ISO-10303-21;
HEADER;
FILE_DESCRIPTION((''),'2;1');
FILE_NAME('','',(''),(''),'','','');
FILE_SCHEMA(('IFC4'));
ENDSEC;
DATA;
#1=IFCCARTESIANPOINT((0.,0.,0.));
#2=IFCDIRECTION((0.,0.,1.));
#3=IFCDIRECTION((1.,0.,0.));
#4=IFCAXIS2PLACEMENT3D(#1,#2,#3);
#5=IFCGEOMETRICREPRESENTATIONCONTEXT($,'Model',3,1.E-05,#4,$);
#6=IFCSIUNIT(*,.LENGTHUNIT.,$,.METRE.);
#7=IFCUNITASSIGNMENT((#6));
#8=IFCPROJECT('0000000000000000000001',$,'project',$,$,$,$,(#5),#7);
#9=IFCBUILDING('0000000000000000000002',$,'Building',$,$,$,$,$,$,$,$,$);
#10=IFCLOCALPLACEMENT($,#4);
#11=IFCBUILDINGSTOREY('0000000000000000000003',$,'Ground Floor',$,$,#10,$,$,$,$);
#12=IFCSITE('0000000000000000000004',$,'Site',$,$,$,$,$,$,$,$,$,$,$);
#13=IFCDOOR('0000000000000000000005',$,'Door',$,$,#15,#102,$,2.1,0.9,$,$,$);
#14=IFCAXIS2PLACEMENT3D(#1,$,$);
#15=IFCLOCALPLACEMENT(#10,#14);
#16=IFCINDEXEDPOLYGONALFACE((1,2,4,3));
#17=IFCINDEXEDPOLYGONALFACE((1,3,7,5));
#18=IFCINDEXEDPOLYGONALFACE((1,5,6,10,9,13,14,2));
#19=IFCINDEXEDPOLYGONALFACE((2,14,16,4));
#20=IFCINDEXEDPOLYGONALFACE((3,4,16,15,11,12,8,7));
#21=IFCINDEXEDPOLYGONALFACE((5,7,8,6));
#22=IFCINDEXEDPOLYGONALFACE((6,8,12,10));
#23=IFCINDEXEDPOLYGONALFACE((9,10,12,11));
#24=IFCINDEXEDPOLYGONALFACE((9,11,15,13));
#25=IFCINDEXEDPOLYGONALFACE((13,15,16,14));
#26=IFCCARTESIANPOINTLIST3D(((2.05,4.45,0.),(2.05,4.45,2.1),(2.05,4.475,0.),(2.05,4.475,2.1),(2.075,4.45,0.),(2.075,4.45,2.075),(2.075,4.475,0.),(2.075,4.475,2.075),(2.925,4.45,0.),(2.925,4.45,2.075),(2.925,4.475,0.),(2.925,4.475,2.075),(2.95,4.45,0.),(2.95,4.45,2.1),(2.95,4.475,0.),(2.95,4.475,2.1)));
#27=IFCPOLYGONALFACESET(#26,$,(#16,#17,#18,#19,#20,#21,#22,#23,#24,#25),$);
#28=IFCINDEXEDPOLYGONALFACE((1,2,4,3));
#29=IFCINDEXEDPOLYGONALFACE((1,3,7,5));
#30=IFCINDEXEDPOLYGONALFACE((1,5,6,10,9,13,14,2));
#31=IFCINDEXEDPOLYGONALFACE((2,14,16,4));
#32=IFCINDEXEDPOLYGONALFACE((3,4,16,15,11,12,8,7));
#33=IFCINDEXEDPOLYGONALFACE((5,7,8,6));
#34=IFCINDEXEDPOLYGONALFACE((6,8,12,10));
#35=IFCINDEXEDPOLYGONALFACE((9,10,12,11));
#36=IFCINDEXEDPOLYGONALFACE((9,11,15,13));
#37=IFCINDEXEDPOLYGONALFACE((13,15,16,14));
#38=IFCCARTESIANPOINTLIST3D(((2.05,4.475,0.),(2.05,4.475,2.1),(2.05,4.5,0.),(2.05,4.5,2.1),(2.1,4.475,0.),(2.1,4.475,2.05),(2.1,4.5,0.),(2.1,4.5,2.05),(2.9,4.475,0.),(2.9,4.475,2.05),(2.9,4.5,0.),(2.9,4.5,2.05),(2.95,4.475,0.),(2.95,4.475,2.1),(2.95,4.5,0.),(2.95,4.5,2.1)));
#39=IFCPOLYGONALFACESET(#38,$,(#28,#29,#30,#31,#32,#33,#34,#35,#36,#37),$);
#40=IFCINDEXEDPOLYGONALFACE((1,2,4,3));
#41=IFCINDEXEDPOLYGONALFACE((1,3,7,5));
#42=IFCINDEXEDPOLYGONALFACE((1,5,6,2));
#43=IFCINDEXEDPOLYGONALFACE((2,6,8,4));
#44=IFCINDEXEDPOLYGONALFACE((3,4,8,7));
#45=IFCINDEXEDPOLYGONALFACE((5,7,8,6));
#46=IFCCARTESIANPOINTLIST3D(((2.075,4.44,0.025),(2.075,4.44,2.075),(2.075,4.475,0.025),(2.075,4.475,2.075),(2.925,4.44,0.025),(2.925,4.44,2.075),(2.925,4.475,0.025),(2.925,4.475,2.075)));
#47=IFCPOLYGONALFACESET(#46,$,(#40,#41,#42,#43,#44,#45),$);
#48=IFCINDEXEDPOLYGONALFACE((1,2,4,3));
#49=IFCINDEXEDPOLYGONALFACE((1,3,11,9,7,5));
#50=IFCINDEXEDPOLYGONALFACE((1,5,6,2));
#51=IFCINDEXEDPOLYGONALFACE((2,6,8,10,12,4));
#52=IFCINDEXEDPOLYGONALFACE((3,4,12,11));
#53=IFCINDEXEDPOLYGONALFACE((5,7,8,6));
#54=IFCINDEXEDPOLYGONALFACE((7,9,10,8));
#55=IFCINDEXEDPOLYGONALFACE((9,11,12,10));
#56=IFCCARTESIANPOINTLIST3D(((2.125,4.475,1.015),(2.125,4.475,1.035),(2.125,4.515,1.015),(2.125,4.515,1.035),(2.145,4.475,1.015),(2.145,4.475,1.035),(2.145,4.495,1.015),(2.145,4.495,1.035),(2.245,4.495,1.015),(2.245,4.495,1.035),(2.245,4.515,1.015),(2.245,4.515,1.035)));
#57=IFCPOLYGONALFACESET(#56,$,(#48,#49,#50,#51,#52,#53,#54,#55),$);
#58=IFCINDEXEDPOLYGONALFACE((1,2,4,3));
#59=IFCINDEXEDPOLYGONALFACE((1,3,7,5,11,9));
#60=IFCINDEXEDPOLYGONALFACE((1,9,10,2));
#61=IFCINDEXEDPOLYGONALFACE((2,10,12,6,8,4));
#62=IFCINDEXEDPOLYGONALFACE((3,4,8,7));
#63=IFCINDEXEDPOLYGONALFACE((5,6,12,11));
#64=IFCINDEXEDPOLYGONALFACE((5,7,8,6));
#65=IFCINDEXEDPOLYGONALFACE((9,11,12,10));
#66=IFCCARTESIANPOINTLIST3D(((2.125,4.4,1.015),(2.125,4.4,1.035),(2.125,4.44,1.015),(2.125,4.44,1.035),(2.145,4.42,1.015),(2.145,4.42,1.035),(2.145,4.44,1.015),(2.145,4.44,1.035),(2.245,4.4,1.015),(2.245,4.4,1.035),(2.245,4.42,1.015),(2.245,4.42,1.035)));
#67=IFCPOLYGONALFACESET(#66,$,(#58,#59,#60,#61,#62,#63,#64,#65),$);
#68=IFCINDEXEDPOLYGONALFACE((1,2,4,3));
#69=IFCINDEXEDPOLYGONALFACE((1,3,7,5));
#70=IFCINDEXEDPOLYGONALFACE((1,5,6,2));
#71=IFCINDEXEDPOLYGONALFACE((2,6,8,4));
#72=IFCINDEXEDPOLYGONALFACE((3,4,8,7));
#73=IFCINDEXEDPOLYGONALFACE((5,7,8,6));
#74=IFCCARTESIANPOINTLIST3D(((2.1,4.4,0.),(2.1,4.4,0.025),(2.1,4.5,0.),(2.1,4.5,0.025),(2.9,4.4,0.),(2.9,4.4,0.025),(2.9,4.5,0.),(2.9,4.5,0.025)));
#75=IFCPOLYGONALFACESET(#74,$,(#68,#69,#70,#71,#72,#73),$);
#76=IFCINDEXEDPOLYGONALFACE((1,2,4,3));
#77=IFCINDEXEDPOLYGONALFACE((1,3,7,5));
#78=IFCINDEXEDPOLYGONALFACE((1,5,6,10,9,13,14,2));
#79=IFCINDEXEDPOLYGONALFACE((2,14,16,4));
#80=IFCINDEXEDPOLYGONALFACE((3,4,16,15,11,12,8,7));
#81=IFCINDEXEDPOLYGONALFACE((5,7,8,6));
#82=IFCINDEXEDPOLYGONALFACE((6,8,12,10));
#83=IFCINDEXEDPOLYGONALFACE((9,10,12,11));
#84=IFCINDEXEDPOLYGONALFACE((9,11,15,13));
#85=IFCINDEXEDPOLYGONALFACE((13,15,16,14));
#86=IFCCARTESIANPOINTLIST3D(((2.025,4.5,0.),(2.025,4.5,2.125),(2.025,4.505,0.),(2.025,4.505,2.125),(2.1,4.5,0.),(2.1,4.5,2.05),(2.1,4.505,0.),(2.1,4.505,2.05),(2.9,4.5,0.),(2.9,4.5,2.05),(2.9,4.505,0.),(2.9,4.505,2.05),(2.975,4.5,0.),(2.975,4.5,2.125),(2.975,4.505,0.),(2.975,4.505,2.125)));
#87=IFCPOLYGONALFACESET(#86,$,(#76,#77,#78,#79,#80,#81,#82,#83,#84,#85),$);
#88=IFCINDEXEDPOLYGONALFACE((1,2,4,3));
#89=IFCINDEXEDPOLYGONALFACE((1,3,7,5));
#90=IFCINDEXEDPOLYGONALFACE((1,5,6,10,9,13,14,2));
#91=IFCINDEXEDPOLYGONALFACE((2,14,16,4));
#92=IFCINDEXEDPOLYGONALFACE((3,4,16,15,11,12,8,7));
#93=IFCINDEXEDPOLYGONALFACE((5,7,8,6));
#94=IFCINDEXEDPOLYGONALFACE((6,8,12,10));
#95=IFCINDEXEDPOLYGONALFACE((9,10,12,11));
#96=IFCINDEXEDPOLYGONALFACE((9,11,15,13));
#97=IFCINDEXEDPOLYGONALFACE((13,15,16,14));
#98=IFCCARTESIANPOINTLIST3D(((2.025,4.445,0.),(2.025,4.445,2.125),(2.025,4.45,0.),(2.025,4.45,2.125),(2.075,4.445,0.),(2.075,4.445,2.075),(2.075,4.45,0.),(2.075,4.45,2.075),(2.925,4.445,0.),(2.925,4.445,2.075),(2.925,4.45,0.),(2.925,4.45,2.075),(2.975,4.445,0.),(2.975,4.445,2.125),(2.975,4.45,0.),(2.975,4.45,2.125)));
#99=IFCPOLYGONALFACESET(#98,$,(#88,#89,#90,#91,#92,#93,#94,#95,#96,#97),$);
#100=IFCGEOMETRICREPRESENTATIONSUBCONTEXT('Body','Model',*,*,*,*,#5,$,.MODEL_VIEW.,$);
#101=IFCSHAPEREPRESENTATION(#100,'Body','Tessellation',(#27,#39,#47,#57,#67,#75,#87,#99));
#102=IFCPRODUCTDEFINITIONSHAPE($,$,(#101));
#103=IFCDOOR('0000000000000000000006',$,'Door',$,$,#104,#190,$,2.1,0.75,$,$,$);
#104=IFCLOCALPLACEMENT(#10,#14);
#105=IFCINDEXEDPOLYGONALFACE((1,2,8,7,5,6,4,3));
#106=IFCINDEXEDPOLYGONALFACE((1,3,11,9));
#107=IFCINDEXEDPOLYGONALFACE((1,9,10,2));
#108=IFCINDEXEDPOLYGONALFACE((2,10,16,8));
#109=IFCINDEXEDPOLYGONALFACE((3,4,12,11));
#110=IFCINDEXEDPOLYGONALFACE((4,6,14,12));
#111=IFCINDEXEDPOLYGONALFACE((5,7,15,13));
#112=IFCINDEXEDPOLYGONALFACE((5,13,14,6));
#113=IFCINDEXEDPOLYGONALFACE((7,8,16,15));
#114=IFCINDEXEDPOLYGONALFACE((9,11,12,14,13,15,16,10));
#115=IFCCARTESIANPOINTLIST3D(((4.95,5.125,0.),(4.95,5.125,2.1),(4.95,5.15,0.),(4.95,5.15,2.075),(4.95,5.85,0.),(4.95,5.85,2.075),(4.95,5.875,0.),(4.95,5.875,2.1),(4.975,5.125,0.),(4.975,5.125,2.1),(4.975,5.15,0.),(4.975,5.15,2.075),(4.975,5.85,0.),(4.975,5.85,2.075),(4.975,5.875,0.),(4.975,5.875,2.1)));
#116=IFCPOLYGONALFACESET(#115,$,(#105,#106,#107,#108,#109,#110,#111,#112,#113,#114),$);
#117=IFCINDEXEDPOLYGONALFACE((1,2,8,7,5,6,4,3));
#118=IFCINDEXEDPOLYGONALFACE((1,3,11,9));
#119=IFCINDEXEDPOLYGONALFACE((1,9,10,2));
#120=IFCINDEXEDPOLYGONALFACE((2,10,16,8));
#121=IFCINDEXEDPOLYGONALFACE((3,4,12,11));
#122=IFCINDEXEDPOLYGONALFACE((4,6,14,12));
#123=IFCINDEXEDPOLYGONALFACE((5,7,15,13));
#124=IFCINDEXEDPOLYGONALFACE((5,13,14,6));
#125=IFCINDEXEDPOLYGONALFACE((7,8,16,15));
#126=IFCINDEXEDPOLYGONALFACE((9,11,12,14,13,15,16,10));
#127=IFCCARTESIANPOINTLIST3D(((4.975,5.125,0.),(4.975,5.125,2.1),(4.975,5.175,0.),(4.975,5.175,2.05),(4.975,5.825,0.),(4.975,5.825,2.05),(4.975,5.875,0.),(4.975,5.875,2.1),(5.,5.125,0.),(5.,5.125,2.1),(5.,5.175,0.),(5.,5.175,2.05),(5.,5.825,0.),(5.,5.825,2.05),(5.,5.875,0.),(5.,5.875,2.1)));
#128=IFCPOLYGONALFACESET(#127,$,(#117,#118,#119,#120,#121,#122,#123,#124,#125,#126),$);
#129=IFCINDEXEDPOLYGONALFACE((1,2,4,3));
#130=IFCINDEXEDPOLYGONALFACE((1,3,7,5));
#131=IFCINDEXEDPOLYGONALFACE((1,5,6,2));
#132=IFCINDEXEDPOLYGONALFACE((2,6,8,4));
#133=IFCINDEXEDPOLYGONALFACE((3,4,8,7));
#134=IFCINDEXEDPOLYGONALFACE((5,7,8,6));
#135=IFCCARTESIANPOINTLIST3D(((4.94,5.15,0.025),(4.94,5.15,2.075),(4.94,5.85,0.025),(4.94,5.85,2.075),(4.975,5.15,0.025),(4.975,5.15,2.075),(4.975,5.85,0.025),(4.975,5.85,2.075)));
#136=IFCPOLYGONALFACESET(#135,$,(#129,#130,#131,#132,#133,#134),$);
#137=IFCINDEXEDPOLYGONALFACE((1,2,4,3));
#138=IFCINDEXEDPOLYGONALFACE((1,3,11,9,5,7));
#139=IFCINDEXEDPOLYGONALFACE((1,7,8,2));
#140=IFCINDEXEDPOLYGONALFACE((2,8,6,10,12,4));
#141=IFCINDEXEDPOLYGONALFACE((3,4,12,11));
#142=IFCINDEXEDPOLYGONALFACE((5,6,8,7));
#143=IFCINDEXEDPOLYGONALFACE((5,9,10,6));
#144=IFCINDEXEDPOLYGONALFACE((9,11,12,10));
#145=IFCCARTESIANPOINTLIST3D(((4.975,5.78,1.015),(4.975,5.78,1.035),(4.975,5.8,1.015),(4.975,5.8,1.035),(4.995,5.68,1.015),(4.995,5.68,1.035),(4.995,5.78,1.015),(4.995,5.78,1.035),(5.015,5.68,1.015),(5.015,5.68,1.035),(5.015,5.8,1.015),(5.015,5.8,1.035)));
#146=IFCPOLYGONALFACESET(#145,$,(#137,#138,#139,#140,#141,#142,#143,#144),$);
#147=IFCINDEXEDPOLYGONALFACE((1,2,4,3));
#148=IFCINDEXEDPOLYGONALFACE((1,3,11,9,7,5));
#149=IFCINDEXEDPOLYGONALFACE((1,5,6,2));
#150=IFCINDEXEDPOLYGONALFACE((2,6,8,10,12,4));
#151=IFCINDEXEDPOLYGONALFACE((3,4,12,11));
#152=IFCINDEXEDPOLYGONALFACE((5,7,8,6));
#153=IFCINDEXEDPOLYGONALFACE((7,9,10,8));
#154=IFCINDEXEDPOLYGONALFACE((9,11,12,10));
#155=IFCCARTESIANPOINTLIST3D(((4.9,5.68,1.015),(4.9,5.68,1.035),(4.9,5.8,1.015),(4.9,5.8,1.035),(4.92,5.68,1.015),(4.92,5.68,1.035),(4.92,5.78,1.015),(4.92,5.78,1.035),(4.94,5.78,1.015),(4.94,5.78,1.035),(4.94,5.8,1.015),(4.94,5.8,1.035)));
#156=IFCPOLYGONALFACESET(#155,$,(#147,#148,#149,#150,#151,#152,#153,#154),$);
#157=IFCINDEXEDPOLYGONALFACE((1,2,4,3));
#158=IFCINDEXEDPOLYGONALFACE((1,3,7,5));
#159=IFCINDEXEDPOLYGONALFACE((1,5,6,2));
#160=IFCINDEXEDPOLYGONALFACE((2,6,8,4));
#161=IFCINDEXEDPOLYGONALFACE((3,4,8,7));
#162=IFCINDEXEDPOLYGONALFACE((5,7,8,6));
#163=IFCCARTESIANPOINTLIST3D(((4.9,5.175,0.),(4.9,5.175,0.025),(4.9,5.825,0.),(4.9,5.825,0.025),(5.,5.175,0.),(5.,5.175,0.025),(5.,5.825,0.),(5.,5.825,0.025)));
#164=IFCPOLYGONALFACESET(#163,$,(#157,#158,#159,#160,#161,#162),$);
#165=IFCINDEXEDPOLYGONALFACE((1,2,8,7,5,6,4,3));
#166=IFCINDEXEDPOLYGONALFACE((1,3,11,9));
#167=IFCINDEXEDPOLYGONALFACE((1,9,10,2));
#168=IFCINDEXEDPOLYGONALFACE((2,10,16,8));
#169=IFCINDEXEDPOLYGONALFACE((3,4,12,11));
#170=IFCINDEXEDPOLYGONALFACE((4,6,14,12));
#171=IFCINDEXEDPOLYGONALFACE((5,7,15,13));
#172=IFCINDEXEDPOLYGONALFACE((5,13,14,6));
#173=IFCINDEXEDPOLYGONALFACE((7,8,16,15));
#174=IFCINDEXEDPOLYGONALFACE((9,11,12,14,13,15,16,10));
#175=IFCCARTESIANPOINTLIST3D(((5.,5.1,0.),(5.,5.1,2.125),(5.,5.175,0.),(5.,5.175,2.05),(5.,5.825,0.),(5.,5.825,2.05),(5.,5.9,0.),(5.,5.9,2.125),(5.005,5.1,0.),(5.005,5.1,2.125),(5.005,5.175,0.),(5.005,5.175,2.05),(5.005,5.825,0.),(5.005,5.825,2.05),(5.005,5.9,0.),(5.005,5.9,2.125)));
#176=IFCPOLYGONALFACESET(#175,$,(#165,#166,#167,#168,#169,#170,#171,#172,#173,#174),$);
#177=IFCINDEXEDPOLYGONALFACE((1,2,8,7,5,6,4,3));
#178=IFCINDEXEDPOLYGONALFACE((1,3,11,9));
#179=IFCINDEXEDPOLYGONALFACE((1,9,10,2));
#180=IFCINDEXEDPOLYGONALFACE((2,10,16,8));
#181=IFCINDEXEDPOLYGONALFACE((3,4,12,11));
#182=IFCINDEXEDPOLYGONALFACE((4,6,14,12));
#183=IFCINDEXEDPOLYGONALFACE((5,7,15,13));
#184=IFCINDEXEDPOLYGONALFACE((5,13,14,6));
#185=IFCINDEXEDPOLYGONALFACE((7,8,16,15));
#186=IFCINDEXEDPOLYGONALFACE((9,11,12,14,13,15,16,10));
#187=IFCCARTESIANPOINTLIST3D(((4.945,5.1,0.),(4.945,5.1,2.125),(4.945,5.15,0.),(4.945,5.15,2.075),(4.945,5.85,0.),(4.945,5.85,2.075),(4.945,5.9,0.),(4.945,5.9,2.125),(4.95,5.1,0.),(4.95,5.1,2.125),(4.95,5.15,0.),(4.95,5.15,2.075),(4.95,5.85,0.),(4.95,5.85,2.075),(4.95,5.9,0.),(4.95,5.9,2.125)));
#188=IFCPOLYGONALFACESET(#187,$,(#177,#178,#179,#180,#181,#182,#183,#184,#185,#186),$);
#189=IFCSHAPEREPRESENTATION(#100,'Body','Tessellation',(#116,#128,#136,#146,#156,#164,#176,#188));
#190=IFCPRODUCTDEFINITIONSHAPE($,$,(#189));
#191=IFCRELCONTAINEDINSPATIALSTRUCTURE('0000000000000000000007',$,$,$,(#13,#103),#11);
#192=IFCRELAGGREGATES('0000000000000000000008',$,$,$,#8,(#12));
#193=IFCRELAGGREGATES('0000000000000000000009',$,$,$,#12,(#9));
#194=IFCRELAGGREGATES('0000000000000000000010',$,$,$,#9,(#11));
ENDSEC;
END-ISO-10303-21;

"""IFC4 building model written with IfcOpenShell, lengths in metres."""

from ifc_helpers import new_model, si_unit, frame, origin_with_axes, place, context, subcontext, project, spatial, line, indexed_curve, outline, extrude, element, save


model = new_model("IFC4")

# Units and contexts
model_context = context("Model", 3, precision=1e-05, world=origin_with_axes())
body_context = subcontext(model_context, "Body", "Model", "MODEL_VIEW")
ifc_project = project(units=[si_unit("LENGTHUNIT", "METRE")], contexts=[model_context])

# Site, building, storey
site = spatial("IfcSite", under=ifc_project, Name="Site")
building = spatial("IfcBuilding", under=site, Name="Building")
storey_placement = place(None, origin_with_axes())
storey = spatial("IfcBuildingStorey", under=building, at=storey_placement, Name="Ground Floor")

# Doors
door_1_placement = place(storey_placement, frame((2.95, 4.5, 0.0), z_axis=(0.0, 0.0, 1.0), x_axis=(-1.0, 0.0, 0.0)))
element("IfcDoor", 1, at=door_1_placement, inside=storey, Name="Door", OverallHeight=2.1, OverallWidth=0.9, context=body_context, shape_type="SweptSolid", body=[
    extrude(outline(indexed_curve([(0.0, 0.0), (0.0, 2.1), (0.9, 2.1), (0.9, 0.0), (0.875, 0.0), (0.875, 2.075), (0.025, 2.075), (0.025, 0.0)], segments=[line(1, 2, 3, 4, 5, 6, 7, 8, 1)])), frame((0.0, 0.025, 0.0), z_axis=(0.0, -1.0, 0.0), x_axis=(1.0, 0.0, 0.0)), (0.0, 0.0, -1.0), 0.025),
    extrude(outline(indexed_curve([(0.0, 0.0), (0.0, 2.1), (0.9, 2.1), (0.9, 0.0), (0.85, 0.0), (0.85, 2.05), (0.05, 2.05), (0.05, 0.0)], segments=[line(1, 2, 3, 4, 5, 6, 7, 8, 1)])), frame((0.0, 0.0, 0.0), z_axis=(0.0, -1.0, 0.0), x_axis=(1.0, 0.0, 0.0)), (0.0, 0.0, -1.0), 0.025),
    extrude(outline(indexed_curve([(0.0, 0.0), (0.85, 0.0), (0.85, 0.035), (0.0, 0.035)], segments=[line(1, 2, 3, 4, 1)])), frame((0.025, 0.025, 0.025), z_axis=(0.0, 0.0, 1.0), x_axis=(1.0, 0.0, 0.0)), (0.0, 0.0, 1.0), 2.05),
    extrude(outline(indexed_curve([(0.0, 0.0), (0.0, -0.04), (-0.12, -0.04), (-0.12, -0.02), (-0.02, -0.02), (-0.02, 0.0)], segments=[line(1, 2, 3, 4, 5, 6, 1)])), frame((0.825, 0.025, 1.015), z_axis=(0.0, 0.0, 1.0), x_axis=(1.0, 0.0, 0.0)), (0.0, 0.0, 1.0), 0.02),
    extrude(outline(indexed_curve([(0.0, 0.0), (0.0, 0.04), (-0.12, 0.04), (-0.12, 0.02), (-0.02, 0.02), (-0.02, 0.0)], segments=[line(1, 2, 3, 4, 5, 6, 1)])), frame((0.825, 0.06, 1.015), z_axis=(0.0, 0.0, 1.0), x_axis=(1.0, 0.0, 0.0)), (0.0, 0.0, 1.0), 0.02),
    extrude(outline(indexed_curve([(0.0, 0.0), (0.8, 0.0), (0.8, 0.1), (0.0, 0.1)], segments=[line(1, 2, 3, 4, 1)])), frame((0.05, 0.0, 0.0), z_axis=(0.0, 0.0, 1.0), x_axis=(1.0, 0.0, 0.0)), (0.0, 0.0, 1.0), 0.025),
    extrude(outline(indexed_curve([(0.0, 0.0), (0.0, 2.125), (0.95, 2.125), (0.95, 0.0), (0.875, 0.0), (0.875, 2.05), (0.075, 2.05), (0.075, 0.0)], segments=[line(1, 2, 3, 4, 5, 6, 7, 8, 1)])), frame((-0.025, -0.005, 0.0), z_axis=(0.0, -1.0, 0.0), x_axis=(1.0, 0.0, 0.0)), (0.0, 0.0, -1.0), 0.005),
    extrude(outline(indexed_curve([(0.0, 0.0), (0.0, 2.125), (0.95, 2.125), (0.95, 0.0), (0.9, 0.0), (0.9, 2.075), (0.05, 2.075), (0.05, 0.0)], segments=[line(1, 2, 3, 4, 5, 6, 7, 8, 1)])), frame((-0.025, 0.05, 0.0), z_axis=(0.0, -1.0, 0.0), x_axis=(1.0, 0.0, 0.0)), (0.0, 0.0, -1.0), 0.005),
])
door_2_placement = place(storey_placement, frame((5.0, 5.125, 0.0), z_axis=(0.0, 0.0, 1.0), x_axis=(0.0, 1.0, 0.0)))
element("IfcDoor", 2, at=door_2_placement, inside=storey, Name="Door", OverallHeight=2.1, OverallWidth=0.75, context=body_context, shape_type="SweptSolid", body=[
    extrude(outline(indexed_curve([(0.0, 0.0), (0.0, 2.1), (0.75, 2.1), (0.75, 0.0), (0.725, 0.0), (0.725, 2.075), (0.025, 2.075), (0.025, 0.0)], segments=[line(1, 2, 3, 4, 5, 6, 7, 8, 1)])), frame((0.0, 0.025, 0.0), z_axis=(0.0, -1.0, 0.0), x_axis=(1.0, 0.0, 0.0)), (0.0, 0.0, -1.0), 0.025),
    extrude(outline(indexed_curve([(0.0, 0.0), (0.0, 2.1), (0.75, 2.1), (0.75, 0.0), (0.7, 0.0), (0.7, 2.05), (0.05, 2.05), (0.05, 0.0)], segments=[line(1, 2, 3, 4, 5, 6, 7, 8, 1)])), frame((0.0, 0.0, 0.0), z_axis=(0.0, -1.0, 0.0), x_axis=(1.0, 0.0, 0.0)), (0.0, 0.0, -1.0), 0.025),
    extrude(outline(indexed_curve([(0.0, 0.0), (0.7, 0.0), (0.7, 0.035), (0.0, 0.035)], segments=[line(1, 2, 3, 4, 1)])), frame((0.025, 0.025, 0.025), z_axis=(0.0, 0.0, 1.0), x_axis=(1.0, 0.0, 0.0)), (0.0, 0.0, 1.0), 2.05),
    extrude(outline(indexed_curve([(0.0, 0.0), (0.0, -0.04), (-0.12, -0.04), (-0.12, -0.02), (-0.02, -0.02), (-0.02, 0.0)], segments=[line(1, 2, 3, 4, 5, 6, 1)])), frame((0.675, 0.025, 1.015), z_axis=(0.0, 0.0, 1.0), x_axis=(1.0, 0.0, 0.0)), (0.0, 0.0, 1.0), 0.02),
    extrude(outline(indexed_curve([(0.0, 0.0), (0.0, 0.04), (-0.12, 0.04), (-0.12, 0.02), (-0.02, 0.02), (-0.02, 0.0)], segments=[line(1, 2, 3, 4, 5, 6, 1)])), frame((0.675, 0.06, 1.015), z_axis=(0.0, 0.0, 1.0), x_axis=(1.0, 0.0, 0.0)), (0.0, 0.0, 1.0), 0.02),
    extrude(outline(indexed_curve([(0.0, 0.0), (0.65, 0.0), (0.65, 0.1), (0.0, 0.1)], segments=[line(1, 2, 3, 4, 1)])), frame((0.05, 0.0, 0.0), z_axis=(0.0, 0.0, 1.0), x_axis=(1.0, 0.0, 0.0)), (0.0, 0.0, 1.0), 0.025),
    extrude(outline(indexed_curve([(0.0, 0.0), (0.0, 2.125), (0.8, 2.125), (0.8, 0.0), (0.725, 0.0), (0.725, 2.05), (0.075, 2.05), (0.075, 0.0)], segments=[line(1, 2, 3, 4, 5, 6, 7, 8, 1)])), frame((-0.025, -0.005, 0.0), z_axis=(0.0, -1.0, 0.0), x_axis=(1.0, 0.0, 0.0)), (0.0, 0.0, -1.0), 0.005),
    extrude(outline(indexed_curve([(0.0, 0.0), (0.0, 2.125), (0.8, 2.125), (0.8, 0.0), (0.75, 0.0), (0.75, 2.075), (0.05, 2.075), (0.05, 0.0)], segments=[line(1, 2, 3, 4, 5, 6, 7, 8, 1)])), frame((-0.025, 0.05, 0.0), z_axis=(0.0, -1.0, 0.0), x_axis=(1.0, 0.0, 0.0)), (0.0, 0.0, -1.0), 0.005),
])

save(model, "model.ifc")
